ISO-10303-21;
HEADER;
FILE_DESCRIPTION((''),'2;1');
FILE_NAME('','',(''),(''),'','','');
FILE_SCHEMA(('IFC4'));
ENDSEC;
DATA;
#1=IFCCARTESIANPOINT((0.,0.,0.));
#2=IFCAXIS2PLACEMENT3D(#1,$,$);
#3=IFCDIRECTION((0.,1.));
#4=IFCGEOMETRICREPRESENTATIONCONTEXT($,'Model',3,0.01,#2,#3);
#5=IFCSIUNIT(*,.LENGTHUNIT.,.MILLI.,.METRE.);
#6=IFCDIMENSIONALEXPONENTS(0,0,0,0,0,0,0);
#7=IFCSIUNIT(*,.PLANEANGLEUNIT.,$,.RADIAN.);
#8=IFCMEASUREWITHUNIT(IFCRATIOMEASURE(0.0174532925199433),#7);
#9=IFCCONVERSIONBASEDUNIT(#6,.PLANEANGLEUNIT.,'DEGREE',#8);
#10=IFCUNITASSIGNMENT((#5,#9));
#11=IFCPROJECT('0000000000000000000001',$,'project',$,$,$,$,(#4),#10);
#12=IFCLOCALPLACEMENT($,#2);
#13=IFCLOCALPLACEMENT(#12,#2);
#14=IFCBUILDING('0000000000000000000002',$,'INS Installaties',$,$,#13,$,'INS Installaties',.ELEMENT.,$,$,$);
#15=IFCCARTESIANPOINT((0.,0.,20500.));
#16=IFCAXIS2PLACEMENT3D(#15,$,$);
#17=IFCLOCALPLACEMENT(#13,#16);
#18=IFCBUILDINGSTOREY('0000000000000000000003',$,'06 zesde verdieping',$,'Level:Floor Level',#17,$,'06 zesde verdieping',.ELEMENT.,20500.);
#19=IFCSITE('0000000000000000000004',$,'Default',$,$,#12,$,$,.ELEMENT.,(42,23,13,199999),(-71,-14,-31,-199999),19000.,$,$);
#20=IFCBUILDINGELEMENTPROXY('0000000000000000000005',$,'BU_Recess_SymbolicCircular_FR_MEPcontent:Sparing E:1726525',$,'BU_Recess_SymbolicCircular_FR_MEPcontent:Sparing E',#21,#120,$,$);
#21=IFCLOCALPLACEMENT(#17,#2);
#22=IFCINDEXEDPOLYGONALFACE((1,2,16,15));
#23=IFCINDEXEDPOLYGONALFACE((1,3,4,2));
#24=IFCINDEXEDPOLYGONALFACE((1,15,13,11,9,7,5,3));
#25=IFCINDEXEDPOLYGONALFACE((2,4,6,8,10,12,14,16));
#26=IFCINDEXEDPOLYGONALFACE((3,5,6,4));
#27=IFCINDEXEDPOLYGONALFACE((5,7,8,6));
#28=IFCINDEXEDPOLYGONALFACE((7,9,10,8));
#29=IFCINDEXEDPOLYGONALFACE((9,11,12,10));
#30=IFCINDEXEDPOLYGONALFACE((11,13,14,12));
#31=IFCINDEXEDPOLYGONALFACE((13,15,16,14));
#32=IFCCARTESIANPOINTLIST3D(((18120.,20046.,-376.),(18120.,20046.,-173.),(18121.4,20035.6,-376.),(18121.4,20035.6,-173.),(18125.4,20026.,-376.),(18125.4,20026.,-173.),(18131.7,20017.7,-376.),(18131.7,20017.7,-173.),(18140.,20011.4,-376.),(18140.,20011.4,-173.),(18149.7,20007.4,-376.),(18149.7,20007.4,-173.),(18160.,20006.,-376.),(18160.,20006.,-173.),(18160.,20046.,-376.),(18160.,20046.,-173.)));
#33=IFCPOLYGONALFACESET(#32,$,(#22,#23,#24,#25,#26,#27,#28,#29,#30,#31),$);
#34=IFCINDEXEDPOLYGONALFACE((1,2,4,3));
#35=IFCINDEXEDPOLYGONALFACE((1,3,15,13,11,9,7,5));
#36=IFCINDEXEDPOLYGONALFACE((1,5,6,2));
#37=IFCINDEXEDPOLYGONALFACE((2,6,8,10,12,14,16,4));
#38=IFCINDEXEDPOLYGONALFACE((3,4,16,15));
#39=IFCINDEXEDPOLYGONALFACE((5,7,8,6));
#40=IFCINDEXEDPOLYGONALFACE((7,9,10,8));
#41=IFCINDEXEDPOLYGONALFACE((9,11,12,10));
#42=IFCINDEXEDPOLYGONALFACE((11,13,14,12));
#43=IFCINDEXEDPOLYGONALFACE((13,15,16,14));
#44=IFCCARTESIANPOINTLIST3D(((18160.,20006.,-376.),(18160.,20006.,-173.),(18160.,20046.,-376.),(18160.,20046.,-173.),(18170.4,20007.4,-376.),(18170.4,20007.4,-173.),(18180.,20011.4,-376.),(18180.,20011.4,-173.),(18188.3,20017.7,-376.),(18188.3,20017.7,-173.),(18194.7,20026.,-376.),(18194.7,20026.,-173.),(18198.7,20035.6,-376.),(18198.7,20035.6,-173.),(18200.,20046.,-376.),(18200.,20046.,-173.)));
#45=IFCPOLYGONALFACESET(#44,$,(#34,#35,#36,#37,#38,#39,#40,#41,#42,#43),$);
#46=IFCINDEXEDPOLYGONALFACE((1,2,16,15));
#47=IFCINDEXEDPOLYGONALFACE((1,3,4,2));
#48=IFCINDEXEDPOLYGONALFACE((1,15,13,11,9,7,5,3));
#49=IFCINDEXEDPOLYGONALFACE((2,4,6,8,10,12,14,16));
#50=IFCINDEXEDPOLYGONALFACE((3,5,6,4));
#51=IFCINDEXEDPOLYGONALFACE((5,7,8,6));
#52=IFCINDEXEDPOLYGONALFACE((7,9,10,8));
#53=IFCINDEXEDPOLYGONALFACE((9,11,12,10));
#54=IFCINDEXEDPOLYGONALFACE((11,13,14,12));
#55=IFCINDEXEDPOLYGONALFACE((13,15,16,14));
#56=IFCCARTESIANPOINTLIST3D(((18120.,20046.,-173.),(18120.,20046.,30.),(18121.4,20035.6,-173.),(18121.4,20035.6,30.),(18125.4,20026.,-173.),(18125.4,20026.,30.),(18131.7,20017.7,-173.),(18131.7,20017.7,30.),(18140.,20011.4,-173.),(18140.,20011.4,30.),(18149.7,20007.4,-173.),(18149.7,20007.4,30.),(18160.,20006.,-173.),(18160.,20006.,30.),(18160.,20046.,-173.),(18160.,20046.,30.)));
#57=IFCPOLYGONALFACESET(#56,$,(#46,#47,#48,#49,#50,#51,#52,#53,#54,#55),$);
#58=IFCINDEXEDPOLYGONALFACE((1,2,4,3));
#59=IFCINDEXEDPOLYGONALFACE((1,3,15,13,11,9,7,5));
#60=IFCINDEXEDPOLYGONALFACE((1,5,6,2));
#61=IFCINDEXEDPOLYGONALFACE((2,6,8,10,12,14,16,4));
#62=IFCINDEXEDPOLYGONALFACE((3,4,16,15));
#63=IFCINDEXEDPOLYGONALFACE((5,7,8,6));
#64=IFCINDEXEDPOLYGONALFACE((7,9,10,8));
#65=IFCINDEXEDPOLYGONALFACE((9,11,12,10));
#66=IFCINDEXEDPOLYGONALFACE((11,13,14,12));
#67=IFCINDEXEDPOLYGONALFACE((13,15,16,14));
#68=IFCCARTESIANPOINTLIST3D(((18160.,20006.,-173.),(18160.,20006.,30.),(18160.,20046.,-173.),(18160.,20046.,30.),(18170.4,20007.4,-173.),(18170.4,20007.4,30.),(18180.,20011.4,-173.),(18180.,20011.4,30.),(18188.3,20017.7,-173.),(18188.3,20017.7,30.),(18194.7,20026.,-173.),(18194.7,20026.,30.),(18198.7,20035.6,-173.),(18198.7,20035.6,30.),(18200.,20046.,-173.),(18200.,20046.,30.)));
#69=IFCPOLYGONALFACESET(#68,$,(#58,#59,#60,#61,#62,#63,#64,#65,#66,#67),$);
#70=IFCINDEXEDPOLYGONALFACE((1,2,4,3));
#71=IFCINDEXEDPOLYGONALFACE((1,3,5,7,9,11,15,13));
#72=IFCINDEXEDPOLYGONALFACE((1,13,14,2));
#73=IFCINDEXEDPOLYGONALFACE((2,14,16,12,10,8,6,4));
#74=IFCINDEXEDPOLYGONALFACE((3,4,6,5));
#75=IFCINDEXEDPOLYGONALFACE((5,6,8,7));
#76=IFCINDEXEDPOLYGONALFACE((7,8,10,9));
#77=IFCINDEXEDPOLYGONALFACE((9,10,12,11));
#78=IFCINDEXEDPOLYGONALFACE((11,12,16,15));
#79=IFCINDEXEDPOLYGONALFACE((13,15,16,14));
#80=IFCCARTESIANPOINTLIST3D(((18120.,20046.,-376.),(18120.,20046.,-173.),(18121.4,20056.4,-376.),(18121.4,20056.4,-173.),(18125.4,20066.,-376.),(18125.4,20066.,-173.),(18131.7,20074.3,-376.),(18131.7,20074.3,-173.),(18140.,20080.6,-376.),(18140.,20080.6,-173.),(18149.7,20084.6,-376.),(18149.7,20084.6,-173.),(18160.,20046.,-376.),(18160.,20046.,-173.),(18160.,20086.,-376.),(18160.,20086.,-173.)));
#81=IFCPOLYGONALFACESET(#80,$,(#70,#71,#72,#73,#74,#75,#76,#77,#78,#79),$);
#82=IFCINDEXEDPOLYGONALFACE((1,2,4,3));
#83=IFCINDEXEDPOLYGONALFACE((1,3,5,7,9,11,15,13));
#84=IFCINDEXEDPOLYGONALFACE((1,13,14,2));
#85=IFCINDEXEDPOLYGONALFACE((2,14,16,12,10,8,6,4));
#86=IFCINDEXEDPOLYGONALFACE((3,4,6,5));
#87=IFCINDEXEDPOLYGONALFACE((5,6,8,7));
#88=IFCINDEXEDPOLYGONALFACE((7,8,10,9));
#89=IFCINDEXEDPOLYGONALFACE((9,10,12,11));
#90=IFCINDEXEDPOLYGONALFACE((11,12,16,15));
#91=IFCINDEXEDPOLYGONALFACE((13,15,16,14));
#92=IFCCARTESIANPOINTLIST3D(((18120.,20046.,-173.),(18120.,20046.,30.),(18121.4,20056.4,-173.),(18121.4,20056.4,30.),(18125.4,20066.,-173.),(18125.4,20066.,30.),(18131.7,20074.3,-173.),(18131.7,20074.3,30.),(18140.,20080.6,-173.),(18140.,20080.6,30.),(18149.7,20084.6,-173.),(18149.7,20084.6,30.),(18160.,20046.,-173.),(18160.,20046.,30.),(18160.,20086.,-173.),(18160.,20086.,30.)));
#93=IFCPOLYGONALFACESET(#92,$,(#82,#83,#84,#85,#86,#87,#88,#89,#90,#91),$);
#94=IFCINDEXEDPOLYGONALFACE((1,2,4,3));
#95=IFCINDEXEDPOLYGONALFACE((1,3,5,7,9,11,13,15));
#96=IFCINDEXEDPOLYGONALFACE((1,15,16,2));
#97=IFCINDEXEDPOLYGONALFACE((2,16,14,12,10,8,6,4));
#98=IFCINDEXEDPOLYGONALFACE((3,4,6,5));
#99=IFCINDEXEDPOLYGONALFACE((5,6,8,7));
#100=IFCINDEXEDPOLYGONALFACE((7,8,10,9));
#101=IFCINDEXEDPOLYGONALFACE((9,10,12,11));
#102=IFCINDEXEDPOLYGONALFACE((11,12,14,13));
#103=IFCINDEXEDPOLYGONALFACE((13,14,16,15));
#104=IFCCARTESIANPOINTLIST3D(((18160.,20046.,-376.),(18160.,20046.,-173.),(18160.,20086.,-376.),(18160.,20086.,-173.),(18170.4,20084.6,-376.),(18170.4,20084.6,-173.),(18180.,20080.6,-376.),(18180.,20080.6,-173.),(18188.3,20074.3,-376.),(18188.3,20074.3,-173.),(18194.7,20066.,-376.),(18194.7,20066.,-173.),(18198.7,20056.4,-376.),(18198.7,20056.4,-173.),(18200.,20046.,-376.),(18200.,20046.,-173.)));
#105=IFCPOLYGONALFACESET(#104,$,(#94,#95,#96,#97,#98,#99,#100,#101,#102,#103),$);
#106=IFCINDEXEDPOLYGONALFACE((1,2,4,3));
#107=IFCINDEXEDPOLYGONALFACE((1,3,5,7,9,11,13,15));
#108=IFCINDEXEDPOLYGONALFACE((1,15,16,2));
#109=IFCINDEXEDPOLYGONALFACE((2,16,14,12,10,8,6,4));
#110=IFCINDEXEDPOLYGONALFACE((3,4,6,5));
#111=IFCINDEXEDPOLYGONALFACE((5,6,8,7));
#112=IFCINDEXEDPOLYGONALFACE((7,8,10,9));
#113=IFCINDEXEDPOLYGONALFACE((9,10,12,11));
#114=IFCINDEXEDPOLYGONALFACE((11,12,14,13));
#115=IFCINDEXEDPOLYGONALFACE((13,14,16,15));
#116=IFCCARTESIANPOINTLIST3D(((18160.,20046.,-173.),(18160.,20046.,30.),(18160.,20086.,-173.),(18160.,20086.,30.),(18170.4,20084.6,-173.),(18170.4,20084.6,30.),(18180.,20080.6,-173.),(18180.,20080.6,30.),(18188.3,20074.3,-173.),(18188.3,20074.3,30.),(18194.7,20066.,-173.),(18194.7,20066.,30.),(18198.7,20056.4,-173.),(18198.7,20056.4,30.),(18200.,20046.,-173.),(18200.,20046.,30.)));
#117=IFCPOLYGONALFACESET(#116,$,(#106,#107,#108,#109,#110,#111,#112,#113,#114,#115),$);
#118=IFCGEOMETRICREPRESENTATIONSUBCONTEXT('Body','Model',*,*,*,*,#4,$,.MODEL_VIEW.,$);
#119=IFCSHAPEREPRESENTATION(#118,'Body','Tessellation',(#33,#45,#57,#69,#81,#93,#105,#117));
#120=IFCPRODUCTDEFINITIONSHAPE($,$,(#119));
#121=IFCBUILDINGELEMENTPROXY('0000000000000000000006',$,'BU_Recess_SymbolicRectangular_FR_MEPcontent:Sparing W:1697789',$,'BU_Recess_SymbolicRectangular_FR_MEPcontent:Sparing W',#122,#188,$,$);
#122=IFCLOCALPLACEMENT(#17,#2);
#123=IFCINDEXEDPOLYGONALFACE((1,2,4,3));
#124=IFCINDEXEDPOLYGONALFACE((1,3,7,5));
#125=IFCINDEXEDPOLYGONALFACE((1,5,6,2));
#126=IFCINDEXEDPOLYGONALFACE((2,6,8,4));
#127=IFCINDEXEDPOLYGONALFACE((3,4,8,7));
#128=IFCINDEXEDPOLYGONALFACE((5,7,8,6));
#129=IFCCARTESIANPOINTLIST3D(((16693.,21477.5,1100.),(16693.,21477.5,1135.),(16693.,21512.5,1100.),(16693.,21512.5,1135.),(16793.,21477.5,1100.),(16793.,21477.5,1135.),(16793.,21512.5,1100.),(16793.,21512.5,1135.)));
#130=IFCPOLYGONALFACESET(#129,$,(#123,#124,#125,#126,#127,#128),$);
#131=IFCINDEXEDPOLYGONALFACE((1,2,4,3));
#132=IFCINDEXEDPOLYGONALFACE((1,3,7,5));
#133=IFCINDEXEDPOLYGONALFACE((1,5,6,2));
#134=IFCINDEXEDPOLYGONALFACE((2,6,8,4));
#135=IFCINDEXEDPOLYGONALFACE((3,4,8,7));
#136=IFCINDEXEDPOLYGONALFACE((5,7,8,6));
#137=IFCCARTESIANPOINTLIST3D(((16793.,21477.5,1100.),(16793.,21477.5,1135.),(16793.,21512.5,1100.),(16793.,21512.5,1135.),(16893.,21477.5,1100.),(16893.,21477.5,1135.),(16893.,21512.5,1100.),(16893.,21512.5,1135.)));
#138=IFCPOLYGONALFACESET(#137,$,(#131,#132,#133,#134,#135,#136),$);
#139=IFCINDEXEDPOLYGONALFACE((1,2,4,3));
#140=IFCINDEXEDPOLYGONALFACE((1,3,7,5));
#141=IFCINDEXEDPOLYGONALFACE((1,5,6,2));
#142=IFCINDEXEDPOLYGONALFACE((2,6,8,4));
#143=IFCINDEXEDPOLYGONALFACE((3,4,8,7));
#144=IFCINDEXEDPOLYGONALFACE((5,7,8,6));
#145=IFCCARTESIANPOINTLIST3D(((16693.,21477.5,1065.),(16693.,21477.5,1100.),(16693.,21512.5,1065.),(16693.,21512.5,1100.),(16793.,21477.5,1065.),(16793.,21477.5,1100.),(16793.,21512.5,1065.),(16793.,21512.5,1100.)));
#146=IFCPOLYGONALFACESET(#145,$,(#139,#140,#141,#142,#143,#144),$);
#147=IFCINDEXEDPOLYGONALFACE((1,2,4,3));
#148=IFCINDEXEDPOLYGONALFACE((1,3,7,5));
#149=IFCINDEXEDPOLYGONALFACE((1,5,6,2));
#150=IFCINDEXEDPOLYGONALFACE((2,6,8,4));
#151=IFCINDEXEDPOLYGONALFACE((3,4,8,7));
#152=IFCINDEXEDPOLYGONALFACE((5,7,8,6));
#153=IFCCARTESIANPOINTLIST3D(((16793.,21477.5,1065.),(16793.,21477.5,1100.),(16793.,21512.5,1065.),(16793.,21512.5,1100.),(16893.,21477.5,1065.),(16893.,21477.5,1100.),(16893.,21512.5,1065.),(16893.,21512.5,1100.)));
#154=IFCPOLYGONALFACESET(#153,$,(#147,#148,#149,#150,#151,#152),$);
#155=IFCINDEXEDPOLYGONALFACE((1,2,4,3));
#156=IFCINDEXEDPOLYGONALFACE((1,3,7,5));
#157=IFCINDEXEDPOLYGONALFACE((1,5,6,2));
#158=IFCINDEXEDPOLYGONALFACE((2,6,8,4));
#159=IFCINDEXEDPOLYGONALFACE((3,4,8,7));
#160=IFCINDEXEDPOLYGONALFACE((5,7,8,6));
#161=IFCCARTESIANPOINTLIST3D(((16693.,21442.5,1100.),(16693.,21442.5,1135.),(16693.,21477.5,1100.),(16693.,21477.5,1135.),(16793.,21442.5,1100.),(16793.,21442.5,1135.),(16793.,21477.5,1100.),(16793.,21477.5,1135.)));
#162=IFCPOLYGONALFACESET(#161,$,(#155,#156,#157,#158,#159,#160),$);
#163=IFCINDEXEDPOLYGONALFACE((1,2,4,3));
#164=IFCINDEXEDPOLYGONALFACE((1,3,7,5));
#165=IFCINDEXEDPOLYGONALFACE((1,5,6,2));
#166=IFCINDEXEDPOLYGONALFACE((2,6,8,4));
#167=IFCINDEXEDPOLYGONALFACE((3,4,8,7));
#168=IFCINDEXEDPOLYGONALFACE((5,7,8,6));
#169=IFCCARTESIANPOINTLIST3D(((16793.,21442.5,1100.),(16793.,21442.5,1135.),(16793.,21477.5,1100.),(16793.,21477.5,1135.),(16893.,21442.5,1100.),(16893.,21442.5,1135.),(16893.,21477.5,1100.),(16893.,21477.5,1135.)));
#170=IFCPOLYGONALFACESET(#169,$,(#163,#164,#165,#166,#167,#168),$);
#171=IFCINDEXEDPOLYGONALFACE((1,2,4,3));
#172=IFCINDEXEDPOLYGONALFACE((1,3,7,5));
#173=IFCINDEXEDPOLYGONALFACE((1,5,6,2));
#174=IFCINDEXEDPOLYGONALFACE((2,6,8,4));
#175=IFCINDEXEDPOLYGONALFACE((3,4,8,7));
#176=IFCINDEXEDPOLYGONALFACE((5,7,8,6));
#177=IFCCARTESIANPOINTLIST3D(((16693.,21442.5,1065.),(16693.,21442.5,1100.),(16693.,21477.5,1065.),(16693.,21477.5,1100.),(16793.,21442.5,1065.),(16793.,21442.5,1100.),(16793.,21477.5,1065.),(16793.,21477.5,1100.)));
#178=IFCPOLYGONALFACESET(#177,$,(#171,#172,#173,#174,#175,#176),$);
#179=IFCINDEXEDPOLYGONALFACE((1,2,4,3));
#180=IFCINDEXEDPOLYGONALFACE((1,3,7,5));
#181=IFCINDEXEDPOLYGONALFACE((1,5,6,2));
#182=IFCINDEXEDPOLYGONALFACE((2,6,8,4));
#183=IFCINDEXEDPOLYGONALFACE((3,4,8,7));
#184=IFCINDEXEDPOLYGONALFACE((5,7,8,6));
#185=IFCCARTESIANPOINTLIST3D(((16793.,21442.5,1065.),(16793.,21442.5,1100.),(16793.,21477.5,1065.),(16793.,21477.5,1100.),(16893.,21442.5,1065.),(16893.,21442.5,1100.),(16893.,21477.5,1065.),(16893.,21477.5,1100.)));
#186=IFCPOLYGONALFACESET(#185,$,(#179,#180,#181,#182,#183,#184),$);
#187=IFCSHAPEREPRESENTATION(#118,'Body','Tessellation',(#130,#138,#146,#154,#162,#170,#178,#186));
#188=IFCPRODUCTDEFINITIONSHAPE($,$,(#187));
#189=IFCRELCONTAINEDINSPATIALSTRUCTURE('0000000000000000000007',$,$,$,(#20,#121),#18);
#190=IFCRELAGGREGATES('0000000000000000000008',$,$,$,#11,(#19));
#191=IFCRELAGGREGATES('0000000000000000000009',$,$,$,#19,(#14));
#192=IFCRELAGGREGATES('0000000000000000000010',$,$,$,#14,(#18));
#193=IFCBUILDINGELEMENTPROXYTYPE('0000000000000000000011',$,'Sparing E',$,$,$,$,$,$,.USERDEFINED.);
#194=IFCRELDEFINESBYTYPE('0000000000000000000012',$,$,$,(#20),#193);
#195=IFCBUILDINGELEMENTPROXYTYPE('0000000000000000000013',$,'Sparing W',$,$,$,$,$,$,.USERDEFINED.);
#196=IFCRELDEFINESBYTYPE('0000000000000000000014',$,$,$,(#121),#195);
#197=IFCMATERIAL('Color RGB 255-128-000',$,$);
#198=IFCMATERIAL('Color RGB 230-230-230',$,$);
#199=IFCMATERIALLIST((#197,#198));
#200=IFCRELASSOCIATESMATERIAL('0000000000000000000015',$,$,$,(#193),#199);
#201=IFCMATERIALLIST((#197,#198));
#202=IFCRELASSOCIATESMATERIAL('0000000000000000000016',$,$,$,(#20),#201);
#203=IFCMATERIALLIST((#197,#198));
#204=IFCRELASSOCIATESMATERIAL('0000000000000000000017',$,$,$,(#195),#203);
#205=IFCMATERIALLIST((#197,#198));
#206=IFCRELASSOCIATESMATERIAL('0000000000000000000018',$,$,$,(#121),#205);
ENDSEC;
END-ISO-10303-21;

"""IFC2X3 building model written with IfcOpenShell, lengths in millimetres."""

from ifc_helpers import new_model, entity, si_unit, converted_unit, direction, frame, frame_2d, origin, place, context, subcontext, project, spatial, polyline, circle_curve, parameter, trimmed, segment, composite_curve, rectangle, outline, extrude, source, transform, mapped, material, material_list, type_object, type_shapes, element, save


model = new_model("IFC2X3")

# Units and contexts
model_context = context("Model", 3, precision=0.01, world=origin(), true_north=direction((0.0, 1.0)))
body_context = subcontext(model_context, "Body", "Model", "MODEL_VIEW")
ifc_project = project(units=[si_unit("LENGTHUNIT", "METRE", prefix="MILLI"), converted_unit("PLANEANGLEUNIT", "DEGREE", entity("IfcRatioMeasure", 0.0174532925199433), si_unit("PLANEANGLEUNIT", "RADIAN"), dimensions=[0, 0, 0, 0, 0, 0, 0])], contexts=[model_context])

# Site, building, storey
site_placement = place(None, origin())
site = spatial("IfcSite", under=ifc_project, at=site_placement, Name="Default", CompositionType="ELEMENT", RefLatitude=(42, 23, 13, 199999), RefLongitude=(-71, -14, -31, -199999), RefElevation=19000.0)
building_placement = place(site_placement, origin())
building = spatial("IfcBuilding", under=site, at=building_placement, Name="INS Installaties", LongName="INS Installaties", CompositionType="ELEMENT")
storey_placement = place(building_placement, frame((0.0, 0.0, 20500.0)))
storey = spatial("IfcBuildingStorey", under=building, at=storey_placement, Name="06 zesde verdieping", ObjectType="Level:Floor Level", LongName="06 zesde verdieping", CompositionType="ELEMENT", Elevation=20500.0)

# Building element proxies
ifc_material_1 = material(Name="Color RGB 255-128-000")
ifc_material_2 = material(Name="Color RGB 230-230-230")
ifc_material_list_1 = material_list([ifc_material_1, ifc_material_2])
ifc_material_list_2 = material_list([ifc_material_1, ifc_material_2])
building_element_proxy_type_1 = type_object("IfcBuildingElementProxyType", Name="Sparing E", PredefinedType="USERDEFINED", material=ifc_material_list_2)
shared_shape_1 = source(origin(), body_context, "Body", "SweptSolid", [
    extrude(outline(composite_curve([segment(trimmed(circle_curve(frame_2d((13.3, 13.3), x_axis=(1.0, 0.0)), 40.0), [parameter(180.0)], [parameter(270.0)], True, "PARAMETER"), True, "CONTINUOUS"), segment(polyline([(13.3, -26.7), (13.3, 13.3)]), True, "CONTINUOUS"), segment(polyline([(13.3, 13.3), (-26.7, 13.3)]), True, "CONTINUOUS")], self_intersect=False)), frame((13.3, 13.3, -403.0), z_axis=(0.0, 0.0, 1.0), x_axis=(-1.0, 0.0, 0.0)), (0.0, 0.0, 1.0), 203.0),
    extrude(outline(composite_curve([segment(polyline([(-26.7, -13.3), (13.3, -13.3)]), True, "CONTINUOUS"), segment(polyline([(13.3, -13.3), (13.3, 26.7)]), True, "CONTINUOUS"), segment(trimmed(circle_curve(frame_2d((13.3, -13.3), x_axis=(1.0, 0.0)), 40.0), [parameter(90.0)], [parameter(180.0)], True, "PARAMETER"), True, "CONTINUOUS")], self_intersect=False)), frame((-13.3, 13.3, -403.0)), (0.0, 0.0, 1.0), 203.0),
    extrude(outline(composite_curve([segment(trimmed(circle_curve(frame_2d((13.3, 13.3), x_axis=(1.0, 0.0)), 40.0), [parameter(180.0)], [parameter(270.0)], True, "PARAMETER"), True, "CONTINUOUS"), segment(polyline([(13.3, -26.7), (13.3, 13.3)]), True, "CONTINUOUS"), segment(polyline([(13.3, 13.3), (-26.7, 13.3)]), True, "CONTINUOUS")], self_intersect=False)), frame((13.3, 13.3, -200.0), z_axis=(0.0, 0.0, 1.0), x_axis=(-1.0, 0.0, 0.0)), (0.0, 0.0, 1.0), 203.0),
    extrude(outline(composite_curve([segment(polyline([(-26.7, -13.3), (13.3, -13.3)]), True, "CONTINUOUS"), segment(polyline([(13.3, -13.3), (13.3, 26.7)]), True, "CONTINUOUS"), segment(trimmed(circle_curve(frame_2d((13.3, -13.3), x_axis=(1.0, 0.0)), 40.0), [parameter(90.0)], [parameter(180.0)], True, "PARAMETER"), True, "CONTINUOUS")], self_intersect=False)), frame((-13.3, 13.3, -200.0)), (0.0, 0.0, 1.0), 203.0),
    extrude(outline(composite_curve([segment(polyline([(-26.7, -13.3), (13.3, -13.3)]), True, "CONTINUOUS"), segment(polyline([(13.3, -13.3), (13.3, 26.7)]), True, "CONTINUOUS"), segment(trimmed(circle_curve(frame_2d((13.3, -13.3), x_axis=(1.0, 0.0)), 40.0), [parameter(90.0)], [parameter(180.0)], True, "PARAMETER"), True, "CONTINUOUS")], self_intersect=False)), frame((13.3, -13.3, -403.0), z_axis=(0.0, 0.0, 1.0), x_axis=(-1.0, 0.0, 0.0)), (0.0, 0.0, 1.0), 203.0),
    extrude(outline(composite_curve([segment(polyline([(-26.7, -13.3), (13.3, -13.3)]), True, "CONTINUOUS"), segment(polyline([(13.3, -13.3), (13.3, 26.7)]), True, "CONTINUOUS"), segment(trimmed(circle_curve(frame_2d((13.3, -13.3), x_axis=(1.0, 0.0)), 40.0), [parameter(90.0)], [parameter(180.0)], True, "PARAMETER"), True, "CONTINUOUS")], self_intersect=False)), frame((13.3, -13.3, -200.0), z_axis=(0.0, 0.0, 1.0), x_axis=(-1.0, 0.0, 0.0)), (0.0, 0.0, 1.0), 203.0),
    extrude(outline(composite_curve([segment(trimmed(circle_curve(frame_2d((13.3, 13.3), x_axis=(1.0, 0.0)), 40.0), [parameter(180.0)], [parameter(270.0)], True, "PARAMETER"), True, "CONTINUOUS"), segment(polyline([(13.3, -26.7), (13.3, 13.3)]), True, "CONTINUOUS"), segment(polyline([(13.3, 13.3), (-26.7, 13.3)]), True, "CONTINUOUS")], self_intersect=False)), frame((-13.3, -13.3, -403.0)), (0.0, 0.0, 1.0), 203.0),
    extrude(outline(composite_curve([segment(trimmed(circle_curve(frame_2d((13.3, 13.3), x_axis=(1.0, 0.0)), 40.0), [parameter(180.0)], [parameter(270.0)], True, "PARAMETER"), True, "CONTINUOUS"), segment(polyline([(13.3, -26.7), (13.3, 13.3)]), True, "CONTINUOUS"), segment(polyline([(13.3, 13.3), (-26.7, 13.3)]), True, "CONTINUOUS")], self_intersect=False)), frame((-13.3, -13.3, -200.0)), (0.0, 0.0, 1.0), 203.0),
])
type_shapes(building_element_proxy_type_1, [shared_shape_1])
proxy_1_placement = place(storey_placement, frame((18160.0, 20046.0, 27.0), z_axis=(0.0, 0.0, 1.0), x_axis=(-1.0, 0.0, 0.0)))
element("IfcBuildingElementProxy", 1, at=proxy_1_placement, inside=storey, type_object=building_element_proxy_type_1, material=ifc_material_list_1, Name="BU_Recess_SymbolicCircular_FR_MEPcontent:Sparing E:1726525", ObjectType="BU_Recess_SymbolicCircular_FR_MEPcontent:Sparing E", context=body_context, shape_type="MappedRepresentation", body=[
    mapped(shared_shape_1, transform((0.0, 0.0, 0.0), scale=1.0)),
])
ifc_material_list_3 = material_list([ifc_material_1, ifc_material_2])
ifc_material_list_4 = material_list([ifc_material_1, ifc_material_2])
building_element_proxy_type_2 = type_object("IfcBuildingElementProxyType", Name="Sparing W", PredefinedType="USERDEFINED", material=ifc_material_list_4)
shared_shape_2 = source(origin(), body_context, "Body", "SweptSolid", [
    extrude(rectangle(XDim=35.0, YDim=100.0, at=frame_2d((0.0, 0.0), x_axis=(1.0, 0.0))), frame((50.0, -49.5, 0.0), z_axis=(0.0, 0.0, 1.0), x_axis=(0.0, -1.0, 0.0)), (0.0, 0.0, 1.0), 35.0),
    extrude(rectangle(XDim=35.0, YDim=100.0, at=frame_2d((0.0, 0.0), x_axis=(1.0, 0.0))), frame((-50.0, -49.5, 0.0), z_axis=(0.0, 0.0, 1.0), x_axis=(0.0, -1.0, 0.0)), (0.0, 0.0, 1.0), 35.0),
    extrude(rectangle(XDim=35.0, YDim=100.0, at=frame_2d((0.0, 0.0), x_axis=(1.0, 0.0))), frame((50.0, -49.5, -35.0), z_axis=(0.0, 0.0, 1.0), x_axis=(0.0, -1.0, 0.0)), (0.0, 0.0, 1.0), 35.0),
    extrude(rectangle(XDim=35.0, YDim=100.0, at=frame_2d((0.0, 0.0), x_axis=(1.0, 0.0))), frame((-50.0, -49.5, -35.0), z_axis=(0.0, 0.0, 1.0), x_axis=(0.0, -1.0, 0.0)), (0.0, 0.0, 1.0), 35.0),
    extrude(rectangle(XDim=35.0, YDim=100.0, at=frame_2d((0.0, 0.0), x_axis=(1.0, 0.0))), frame((50.0, -14.5, 0.0), z_axis=(0.0, 0.0, 1.0), x_axis=(0.0, -1.0, 0.0)), (0.0, 0.0, 1.0), 35.0),
    extrude(rectangle(XDim=35.0, YDim=100.0, at=frame_2d((0.0, 0.0), x_axis=(1.0, 0.0))), frame((-50.0, -14.5, 0.0), z_axis=(0.0, 0.0, 1.0), x_axis=(0.0, -1.0, 0.0)), (0.0, 0.0, 1.0), 35.0),
    extrude(rectangle(XDim=35.0, YDim=100.0, at=frame_2d((0.0, 0.0), x_axis=(1.0, 0.0))), frame((50.0, -14.5, -35.0), z_axis=(0.0, 0.0, 1.0), x_axis=(0.0, -1.0, 0.0)), (0.0, 0.0, 1.0), 35.0),
    extrude(rectangle(XDim=35.0, YDim=100.0, at=frame_2d((0.0, 0.0), x_axis=(1.0, 0.0))), frame((-50.0, -14.5, -35.0), z_axis=(0.0, 0.0, 1.0), x_axis=(0.0, -1.0, 0.0)), (0.0, 0.0, 1.0), 35.0),
])
type_shapes(building_element_proxy_type_2, [shared_shape_2])
proxy_2_placement = place(storey_placement, frame((16793.0, 21445.5, 1100.0), z_axis=(0.0, 0.0, 1.0), x_axis=(-1.0, 0.0, 0.0)))
element("IfcBuildingElementProxy", 2, at=proxy_2_placement, inside=storey, type_object=building_element_proxy_type_2, material=ifc_material_list_3, Name="BU_Recess_SymbolicRectangular_FR_MEPcontent:Sparing W:1697789", ObjectType="BU_Recess_SymbolicRectangular_FR_MEPcontent:Sparing W", context=body_context, shape_type="MappedRepresentation", body=[
    mapped(shared_shape_2, transform((0.0, 0.0, 0.0), scale=1.0)),
])

save(model, "model.ifc")
